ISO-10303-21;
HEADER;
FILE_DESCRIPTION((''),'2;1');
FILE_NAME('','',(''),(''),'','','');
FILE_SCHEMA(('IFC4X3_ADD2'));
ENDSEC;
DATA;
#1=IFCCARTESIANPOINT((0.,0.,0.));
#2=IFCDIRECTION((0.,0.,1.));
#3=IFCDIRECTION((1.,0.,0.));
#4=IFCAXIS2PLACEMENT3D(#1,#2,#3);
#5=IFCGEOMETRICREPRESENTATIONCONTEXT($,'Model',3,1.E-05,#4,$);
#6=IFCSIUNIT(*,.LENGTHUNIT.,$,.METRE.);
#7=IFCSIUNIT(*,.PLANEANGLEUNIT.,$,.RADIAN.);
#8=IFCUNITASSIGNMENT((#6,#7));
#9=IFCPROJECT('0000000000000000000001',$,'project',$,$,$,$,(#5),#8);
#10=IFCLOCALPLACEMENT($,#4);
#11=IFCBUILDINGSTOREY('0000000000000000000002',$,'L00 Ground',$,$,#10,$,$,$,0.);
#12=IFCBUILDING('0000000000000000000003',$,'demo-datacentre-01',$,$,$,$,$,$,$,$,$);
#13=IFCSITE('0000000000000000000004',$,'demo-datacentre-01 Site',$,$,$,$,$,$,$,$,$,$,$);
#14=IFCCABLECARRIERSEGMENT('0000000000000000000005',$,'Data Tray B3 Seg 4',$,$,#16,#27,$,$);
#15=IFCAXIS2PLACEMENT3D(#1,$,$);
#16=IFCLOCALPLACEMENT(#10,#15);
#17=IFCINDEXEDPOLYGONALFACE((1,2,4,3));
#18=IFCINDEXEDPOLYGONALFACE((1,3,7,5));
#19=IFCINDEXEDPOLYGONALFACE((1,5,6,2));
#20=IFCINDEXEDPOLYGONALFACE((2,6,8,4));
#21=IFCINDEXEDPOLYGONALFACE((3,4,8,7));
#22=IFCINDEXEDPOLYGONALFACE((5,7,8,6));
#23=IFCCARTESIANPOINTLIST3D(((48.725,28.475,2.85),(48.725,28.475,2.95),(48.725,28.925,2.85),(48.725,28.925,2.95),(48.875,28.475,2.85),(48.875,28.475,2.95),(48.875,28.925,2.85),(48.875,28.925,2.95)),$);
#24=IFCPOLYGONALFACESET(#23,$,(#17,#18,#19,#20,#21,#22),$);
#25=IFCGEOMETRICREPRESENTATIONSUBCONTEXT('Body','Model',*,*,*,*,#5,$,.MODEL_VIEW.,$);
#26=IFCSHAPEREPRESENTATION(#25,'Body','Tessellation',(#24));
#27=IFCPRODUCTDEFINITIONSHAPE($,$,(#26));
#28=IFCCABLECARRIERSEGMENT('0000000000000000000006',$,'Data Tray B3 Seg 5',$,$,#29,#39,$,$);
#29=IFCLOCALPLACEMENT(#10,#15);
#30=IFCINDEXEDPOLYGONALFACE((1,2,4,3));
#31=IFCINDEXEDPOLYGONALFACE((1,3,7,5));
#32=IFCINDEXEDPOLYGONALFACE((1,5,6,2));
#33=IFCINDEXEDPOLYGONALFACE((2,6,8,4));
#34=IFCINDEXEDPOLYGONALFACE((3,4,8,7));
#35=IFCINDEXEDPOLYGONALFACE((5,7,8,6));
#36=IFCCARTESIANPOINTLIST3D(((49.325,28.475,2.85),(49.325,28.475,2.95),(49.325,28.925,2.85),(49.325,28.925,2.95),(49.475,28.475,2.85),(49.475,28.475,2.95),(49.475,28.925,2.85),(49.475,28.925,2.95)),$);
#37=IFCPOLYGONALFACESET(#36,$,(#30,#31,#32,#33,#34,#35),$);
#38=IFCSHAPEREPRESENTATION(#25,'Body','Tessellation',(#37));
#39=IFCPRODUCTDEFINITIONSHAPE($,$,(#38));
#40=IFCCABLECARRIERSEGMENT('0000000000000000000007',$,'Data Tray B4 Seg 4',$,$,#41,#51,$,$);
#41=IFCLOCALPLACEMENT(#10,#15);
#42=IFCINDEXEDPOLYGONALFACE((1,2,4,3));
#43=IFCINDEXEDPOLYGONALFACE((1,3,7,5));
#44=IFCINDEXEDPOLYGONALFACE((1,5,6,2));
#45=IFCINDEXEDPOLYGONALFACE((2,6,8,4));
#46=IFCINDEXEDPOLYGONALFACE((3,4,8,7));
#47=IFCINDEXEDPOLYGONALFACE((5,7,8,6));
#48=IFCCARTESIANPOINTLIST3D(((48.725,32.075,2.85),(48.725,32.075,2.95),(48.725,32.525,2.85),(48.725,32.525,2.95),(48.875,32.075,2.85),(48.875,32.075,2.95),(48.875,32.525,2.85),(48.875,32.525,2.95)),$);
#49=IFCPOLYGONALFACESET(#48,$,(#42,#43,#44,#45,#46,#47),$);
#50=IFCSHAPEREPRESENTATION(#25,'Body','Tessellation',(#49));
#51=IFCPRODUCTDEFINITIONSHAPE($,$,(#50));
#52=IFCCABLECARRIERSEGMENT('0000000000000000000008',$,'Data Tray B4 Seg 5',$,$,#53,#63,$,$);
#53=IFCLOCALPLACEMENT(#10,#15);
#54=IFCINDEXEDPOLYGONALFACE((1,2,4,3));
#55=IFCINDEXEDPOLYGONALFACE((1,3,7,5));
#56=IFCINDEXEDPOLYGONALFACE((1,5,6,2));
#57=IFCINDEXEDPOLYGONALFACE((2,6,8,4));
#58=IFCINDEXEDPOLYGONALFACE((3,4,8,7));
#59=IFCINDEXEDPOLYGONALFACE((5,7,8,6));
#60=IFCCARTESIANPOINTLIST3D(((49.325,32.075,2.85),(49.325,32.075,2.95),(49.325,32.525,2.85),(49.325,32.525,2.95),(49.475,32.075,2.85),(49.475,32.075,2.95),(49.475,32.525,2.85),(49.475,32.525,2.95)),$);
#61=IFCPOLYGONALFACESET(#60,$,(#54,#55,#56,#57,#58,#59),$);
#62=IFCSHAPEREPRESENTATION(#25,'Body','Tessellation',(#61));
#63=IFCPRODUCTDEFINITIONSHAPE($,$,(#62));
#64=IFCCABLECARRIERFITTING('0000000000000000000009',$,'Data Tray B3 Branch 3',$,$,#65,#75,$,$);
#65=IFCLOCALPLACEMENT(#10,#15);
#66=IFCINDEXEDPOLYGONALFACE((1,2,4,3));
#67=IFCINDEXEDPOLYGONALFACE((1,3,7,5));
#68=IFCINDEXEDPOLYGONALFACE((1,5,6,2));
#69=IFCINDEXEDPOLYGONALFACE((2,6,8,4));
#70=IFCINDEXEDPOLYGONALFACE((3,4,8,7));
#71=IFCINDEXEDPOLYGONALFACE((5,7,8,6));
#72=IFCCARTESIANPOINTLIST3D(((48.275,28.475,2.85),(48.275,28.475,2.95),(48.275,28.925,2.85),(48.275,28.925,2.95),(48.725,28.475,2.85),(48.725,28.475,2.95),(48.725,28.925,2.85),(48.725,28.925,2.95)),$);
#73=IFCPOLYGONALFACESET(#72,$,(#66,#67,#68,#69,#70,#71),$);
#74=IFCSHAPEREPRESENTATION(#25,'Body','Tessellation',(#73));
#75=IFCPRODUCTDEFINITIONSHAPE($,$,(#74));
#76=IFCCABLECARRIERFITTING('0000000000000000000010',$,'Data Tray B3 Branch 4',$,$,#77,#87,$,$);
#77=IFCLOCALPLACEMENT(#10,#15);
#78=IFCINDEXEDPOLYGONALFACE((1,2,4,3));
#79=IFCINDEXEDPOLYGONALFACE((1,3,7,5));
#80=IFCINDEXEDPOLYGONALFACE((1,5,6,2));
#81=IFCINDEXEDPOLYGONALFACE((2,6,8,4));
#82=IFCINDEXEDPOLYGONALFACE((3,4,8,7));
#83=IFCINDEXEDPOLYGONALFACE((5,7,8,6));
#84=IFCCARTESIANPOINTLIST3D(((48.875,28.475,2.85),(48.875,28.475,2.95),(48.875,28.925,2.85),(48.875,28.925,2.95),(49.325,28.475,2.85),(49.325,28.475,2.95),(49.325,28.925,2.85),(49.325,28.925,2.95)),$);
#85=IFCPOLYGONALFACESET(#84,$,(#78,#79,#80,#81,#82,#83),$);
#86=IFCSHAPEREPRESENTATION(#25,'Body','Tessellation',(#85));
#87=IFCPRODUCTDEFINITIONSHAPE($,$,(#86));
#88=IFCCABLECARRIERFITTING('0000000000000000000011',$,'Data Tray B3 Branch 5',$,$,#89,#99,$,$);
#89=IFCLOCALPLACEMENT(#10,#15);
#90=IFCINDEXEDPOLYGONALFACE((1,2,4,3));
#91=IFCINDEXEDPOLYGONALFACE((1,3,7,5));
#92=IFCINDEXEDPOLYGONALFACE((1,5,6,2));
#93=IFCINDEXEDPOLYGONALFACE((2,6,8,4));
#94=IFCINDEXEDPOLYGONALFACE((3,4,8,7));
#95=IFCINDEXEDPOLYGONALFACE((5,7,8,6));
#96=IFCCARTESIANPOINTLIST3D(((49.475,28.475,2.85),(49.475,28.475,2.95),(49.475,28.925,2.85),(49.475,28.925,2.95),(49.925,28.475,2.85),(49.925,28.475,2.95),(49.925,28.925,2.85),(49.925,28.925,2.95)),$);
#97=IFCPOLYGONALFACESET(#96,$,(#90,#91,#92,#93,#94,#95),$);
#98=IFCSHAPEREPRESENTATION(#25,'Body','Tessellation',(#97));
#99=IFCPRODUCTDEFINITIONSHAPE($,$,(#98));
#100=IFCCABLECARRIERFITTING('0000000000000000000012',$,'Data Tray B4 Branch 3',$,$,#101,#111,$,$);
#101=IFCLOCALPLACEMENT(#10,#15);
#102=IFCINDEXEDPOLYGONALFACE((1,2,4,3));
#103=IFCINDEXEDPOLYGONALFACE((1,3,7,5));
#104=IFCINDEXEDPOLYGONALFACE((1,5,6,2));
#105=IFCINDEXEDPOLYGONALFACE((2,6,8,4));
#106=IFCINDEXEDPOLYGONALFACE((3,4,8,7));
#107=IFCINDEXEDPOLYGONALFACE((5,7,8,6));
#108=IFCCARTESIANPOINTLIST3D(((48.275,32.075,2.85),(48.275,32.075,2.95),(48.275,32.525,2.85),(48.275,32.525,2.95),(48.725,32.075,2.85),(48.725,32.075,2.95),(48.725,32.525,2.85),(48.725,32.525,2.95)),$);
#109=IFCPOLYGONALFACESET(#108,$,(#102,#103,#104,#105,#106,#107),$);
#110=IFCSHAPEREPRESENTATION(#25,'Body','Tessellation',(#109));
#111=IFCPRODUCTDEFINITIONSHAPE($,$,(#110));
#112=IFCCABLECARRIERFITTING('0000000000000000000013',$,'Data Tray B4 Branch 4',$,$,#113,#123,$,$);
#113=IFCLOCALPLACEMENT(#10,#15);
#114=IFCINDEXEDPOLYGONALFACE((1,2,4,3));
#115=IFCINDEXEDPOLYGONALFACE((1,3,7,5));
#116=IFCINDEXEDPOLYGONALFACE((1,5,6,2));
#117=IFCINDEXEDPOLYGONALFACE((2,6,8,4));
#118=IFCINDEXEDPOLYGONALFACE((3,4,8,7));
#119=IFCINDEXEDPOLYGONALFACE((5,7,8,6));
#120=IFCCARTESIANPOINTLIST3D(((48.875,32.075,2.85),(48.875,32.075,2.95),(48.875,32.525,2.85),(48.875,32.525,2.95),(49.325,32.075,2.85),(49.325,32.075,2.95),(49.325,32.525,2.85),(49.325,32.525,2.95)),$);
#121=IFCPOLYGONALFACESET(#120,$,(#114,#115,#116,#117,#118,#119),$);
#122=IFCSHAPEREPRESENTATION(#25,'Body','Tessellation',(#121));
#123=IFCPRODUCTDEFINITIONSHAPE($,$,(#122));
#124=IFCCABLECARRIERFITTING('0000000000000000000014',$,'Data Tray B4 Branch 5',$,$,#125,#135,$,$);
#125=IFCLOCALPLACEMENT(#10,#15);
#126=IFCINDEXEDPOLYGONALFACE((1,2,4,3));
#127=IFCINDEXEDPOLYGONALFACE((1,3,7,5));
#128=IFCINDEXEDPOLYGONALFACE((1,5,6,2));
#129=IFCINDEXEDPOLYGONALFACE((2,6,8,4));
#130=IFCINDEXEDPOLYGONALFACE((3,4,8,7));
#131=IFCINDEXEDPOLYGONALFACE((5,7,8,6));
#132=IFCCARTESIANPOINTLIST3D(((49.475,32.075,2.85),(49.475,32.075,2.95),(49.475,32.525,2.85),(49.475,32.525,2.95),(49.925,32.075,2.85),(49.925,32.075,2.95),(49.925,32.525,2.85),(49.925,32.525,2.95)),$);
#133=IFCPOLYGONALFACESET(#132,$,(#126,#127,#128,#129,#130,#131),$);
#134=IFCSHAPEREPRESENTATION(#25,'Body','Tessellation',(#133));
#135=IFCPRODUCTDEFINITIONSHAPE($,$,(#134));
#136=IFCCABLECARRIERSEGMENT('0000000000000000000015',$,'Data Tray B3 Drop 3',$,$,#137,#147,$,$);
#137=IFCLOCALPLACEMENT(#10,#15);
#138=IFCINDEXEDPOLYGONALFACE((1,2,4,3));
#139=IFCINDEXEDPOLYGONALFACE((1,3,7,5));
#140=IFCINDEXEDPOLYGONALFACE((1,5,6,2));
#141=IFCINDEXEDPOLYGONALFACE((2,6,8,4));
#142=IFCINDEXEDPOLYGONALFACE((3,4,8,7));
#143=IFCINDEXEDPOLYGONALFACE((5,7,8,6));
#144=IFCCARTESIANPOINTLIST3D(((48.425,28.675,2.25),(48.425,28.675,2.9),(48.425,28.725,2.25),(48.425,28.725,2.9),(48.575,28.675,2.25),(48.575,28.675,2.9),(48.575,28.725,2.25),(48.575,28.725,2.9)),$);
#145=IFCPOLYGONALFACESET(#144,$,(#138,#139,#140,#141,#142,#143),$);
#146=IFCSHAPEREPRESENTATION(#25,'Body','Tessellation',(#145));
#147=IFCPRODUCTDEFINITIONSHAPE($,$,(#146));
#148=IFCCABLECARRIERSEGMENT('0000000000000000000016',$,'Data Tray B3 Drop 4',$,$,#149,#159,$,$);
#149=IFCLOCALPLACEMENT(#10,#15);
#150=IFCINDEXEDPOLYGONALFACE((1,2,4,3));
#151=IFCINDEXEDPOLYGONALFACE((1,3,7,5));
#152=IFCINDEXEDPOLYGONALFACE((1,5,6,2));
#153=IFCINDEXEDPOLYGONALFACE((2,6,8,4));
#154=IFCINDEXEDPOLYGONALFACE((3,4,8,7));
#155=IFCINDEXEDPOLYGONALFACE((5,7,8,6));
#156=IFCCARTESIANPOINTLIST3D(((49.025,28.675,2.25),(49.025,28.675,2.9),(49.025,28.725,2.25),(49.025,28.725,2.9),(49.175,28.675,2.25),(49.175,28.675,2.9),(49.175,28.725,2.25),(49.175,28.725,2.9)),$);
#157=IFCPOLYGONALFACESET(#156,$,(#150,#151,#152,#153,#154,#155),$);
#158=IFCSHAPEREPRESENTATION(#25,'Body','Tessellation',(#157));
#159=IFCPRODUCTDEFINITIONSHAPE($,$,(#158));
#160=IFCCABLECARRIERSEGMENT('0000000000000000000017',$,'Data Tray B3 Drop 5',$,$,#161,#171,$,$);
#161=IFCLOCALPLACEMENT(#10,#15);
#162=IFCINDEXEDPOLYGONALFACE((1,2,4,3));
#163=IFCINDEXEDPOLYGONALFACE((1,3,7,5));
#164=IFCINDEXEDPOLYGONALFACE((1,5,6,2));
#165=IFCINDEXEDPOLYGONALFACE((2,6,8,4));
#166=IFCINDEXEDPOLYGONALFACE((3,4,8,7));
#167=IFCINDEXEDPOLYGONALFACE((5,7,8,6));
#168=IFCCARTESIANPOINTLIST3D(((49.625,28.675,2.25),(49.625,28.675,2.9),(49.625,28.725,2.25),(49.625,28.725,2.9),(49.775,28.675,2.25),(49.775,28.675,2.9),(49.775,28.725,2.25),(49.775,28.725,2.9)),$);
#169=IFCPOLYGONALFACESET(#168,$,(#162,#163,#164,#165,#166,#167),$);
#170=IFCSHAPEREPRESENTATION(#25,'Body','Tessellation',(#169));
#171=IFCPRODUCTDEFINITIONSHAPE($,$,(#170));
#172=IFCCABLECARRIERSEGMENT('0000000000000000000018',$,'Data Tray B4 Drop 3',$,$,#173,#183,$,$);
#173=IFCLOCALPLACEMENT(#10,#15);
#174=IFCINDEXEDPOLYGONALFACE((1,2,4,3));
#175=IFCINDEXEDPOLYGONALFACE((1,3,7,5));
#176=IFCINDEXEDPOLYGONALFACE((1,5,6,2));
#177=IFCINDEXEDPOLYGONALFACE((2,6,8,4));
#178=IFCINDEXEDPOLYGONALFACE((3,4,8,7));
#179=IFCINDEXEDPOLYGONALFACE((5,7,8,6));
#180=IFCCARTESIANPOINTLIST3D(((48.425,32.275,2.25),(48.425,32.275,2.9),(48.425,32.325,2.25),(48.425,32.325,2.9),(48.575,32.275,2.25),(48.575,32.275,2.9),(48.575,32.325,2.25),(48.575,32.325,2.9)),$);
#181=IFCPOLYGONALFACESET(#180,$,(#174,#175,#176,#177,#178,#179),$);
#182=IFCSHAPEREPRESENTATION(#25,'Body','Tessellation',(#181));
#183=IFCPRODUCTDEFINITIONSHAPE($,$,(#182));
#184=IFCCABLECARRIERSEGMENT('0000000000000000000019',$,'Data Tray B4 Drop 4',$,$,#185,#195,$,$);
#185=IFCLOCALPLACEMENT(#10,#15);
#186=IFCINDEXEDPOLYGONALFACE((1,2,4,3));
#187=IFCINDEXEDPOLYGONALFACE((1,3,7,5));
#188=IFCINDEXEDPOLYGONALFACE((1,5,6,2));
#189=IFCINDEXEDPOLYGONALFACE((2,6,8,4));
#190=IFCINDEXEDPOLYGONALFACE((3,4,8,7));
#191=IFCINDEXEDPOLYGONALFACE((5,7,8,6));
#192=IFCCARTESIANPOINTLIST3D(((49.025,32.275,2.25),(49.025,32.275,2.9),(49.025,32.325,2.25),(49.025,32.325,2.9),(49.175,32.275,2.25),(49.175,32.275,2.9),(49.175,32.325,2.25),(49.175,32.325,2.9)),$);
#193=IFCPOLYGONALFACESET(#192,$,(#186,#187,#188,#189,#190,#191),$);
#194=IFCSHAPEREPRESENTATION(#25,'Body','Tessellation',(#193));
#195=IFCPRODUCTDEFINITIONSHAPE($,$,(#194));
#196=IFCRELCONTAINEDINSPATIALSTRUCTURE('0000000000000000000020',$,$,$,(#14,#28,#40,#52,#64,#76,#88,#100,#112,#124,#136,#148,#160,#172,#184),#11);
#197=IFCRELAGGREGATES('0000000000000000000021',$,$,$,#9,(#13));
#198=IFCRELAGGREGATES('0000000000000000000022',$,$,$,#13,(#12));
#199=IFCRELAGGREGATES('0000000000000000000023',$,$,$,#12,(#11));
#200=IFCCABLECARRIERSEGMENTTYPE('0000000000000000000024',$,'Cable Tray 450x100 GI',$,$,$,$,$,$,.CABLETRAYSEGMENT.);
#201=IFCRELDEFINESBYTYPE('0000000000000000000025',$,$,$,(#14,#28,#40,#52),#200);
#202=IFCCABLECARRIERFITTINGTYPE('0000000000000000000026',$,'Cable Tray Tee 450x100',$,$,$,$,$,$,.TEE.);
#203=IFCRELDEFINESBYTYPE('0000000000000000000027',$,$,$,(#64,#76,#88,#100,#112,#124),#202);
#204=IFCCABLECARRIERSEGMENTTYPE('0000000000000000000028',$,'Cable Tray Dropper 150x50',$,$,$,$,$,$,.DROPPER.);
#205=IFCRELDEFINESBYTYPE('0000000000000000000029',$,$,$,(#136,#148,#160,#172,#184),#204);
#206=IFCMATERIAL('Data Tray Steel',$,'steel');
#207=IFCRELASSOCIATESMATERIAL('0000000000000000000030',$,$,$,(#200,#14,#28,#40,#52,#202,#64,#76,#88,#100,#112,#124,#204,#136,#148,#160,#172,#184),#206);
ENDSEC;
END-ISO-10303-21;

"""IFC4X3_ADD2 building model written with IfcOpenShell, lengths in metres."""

from ifc_helpers import new_model, si_unit, frame, origin_with_axes, place, context, subcontext, project, spatial, rectangle, extrude, material, type_object, element, save


model = new_model("IFC4X3_ADD2")

# Units and contexts
model_context = context("Model", 3, precision=1e-05, world=origin_with_axes())
body_context = subcontext(model_context, "Body", "Model", "MODEL_VIEW")
ifc_project = project(units=[si_unit("LENGTHUNIT", "METRE"), si_unit("PLANEANGLEUNIT", "RADIAN")], contexts=[model_context])

# Site, building, storey
site = spatial("IfcSite", under=ifc_project, Name="demo-datacentre-01 Site")
building = spatial("IfcBuilding", under=site, Name="demo-datacentre-01")
storey_placement = place(None, origin_with_axes())
storey = spatial("IfcBuildingStorey", under=building, at=storey_placement, Name="L00 Ground", Elevation=0.0)

# Cable carrier segments
ifc_material_1 = material(Name="Data Tray Steel", Category="steel")
cable_carrier_segment_type_1 = type_object("IfcCableCarrierSegmentType", Name="Cable Tray 450x100 GI", PredefinedType="CABLETRAYSEGMENT", material=ifc_material_1)
cable_carrier_segment_1_placement = place(storey_placement, frame((48.725, 28.7, 2.9), z_axis=(1.0, 0.0, 0.0), x_axis=(0.0, 1.0, 0.0)))
element("IfcCableCarrierSegment", 1, at=cable_carrier_segment_1_placement, inside=storey, type_object=cable_carrier_segment_type_1, material=ifc_material_1, Name="Data Tray B3 Seg 4", context=body_context, shape_type="SweptSolid", body=[
    extrude(rectangle(XDim=0.45, YDim=0.1), origin_with_axes(), (0.0, 0.0, 1.0), 0.15),
])
cable_carrier_segment_2_placement = place(storey_placement, frame((49.325, 28.7, 2.9), z_axis=(1.0, 0.0, 0.0), x_axis=(0.0, 1.0, 0.0)))
element("IfcCableCarrierSegment", 2, at=cable_carrier_segment_2_placement, inside=storey, type_object=cable_carrier_segment_type_1, material=ifc_material_1, Name="Data Tray B3 Seg 5", context=body_context, shape_type="SweptSolid", body=[
    extrude(rectangle(XDim=0.45, YDim=0.1), origin_with_axes(), (0.0, 0.0, 1.0), 0.15),
])
cable_carrier_segment_3_placement = place(storey_placement, frame((48.725, 32.3, 2.9), z_axis=(1.0, 0.0, 0.0), x_axis=(0.0, 1.0, 0.0)))
element("IfcCableCarrierSegment", 3, at=cable_carrier_segment_3_placement, inside=storey, type_object=cable_carrier_segment_type_1, material=ifc_material_1, Name="Data Tray B4 Seg 4", context=body_context, shape_type="SweptSolid", body=[
    extrude(rectangle(XDim=0.45, YDim=0.1), origin_with_axes(), (0.0, 0.0, 1.0), 0.15),
])
cable_carrier_segment_4_placement = place(storey_placement, frame((49.325, 32.3, 2.9), z_axis=(1.0, 0.0, 0.0), x_axis=(0.0, 1.0, 0.0)))
element("IfcCableCarrierSegment", 4, at=cable_carrier_segment_4_placement, inside=storey, type_object=cable_carrier_segment_type_1, material=ifc_material_1, Name="Data Tray B4 Seg 5", context=body_context, shape_type="SweptSolid", body=[
    extrude(rectangle(XDim=0.45, YDim=0.1), origin_with_axes(), (0.0, 0.0, 1.0), 0.15),
])

# Cable carrier fittings
cable_carrier_fitting_type = type_object("IfcCableCarrierFittingType", Name="Cable Tray Tee 450x100", PredefinedType="TEE", material=ifc_material_1)
for number, where, z_axis, x_axis, name in (
    (5, (48.5, 28.7, 2.85), (0.0, 0.0, 1.0), (1.0, 0.0, 0.0), "Data Tray B3 Branch 3"),
    (6, (49.1, 28.7, 2.85), (0.0, 0.0, 1.0), (1.0, 0.0, 0.0), "Data Tray B3 Branch 4"),
    (7, (49.7, 28.7, 2.85), (0.0, 0.0, 1.0), (1.0, 0.0, 0.0), "Data Tray B3 Branch 5"),
    (8, (48.5, 32.3, 2.85), (0.0, 0.0, 1.0), (1.0, 0.0, 0.0), "Data Tray B4 Branch 3"),
    (9, (49.1, 32.3, 2.85), (0.0, 0.0, 1.0), (1.0, 0.0, 0.0), "Data Tray B4 Branch 4"),
    (10, (49.7, 32.3, 2.85), (0.0, 0.0, 1.0), (1.0, 0.0, 0.0), "Data Tray B4 Branch 5"),
):
    element("IfcCableCarrierFitting", number, at=place(storey_placement, frame(where, z_axis=z_axis, x_axis=x_axis)), inside=storey, type_object=cable_carrier_fitting_type, material=ifc_material_1, Name=name, context=body_context, shape_type="SweptSolid", body=[
        extrude(rectangle(XDim=0.45, YDim=0.45), origin_with_axes(), (0.0, 0.0, 1.0), 0.1),
    ])

# Cable carrier segments
cable_carrier_segment_type_2 = type_object("IfcCableCarrierSegmentType", Name="Cable Tray Dropper 150x50", PredefinedType="DROPPER", material=ifc_material_1)
for number, where, z_axis, x_axis, name in (
    (11, (48.5, 28.7, 2.9), (0.0, 0.0, -1.0), (1.0, 0.0, 0.0), "Data Tray B3 Drop 3"),
    (12, (49.1, 28.7, 2.9), (0.0, 0.0, -1.0), (1.0, 0.0, 0.0), "Data Tray B3 Drop 4"),
    (13, (49.7, 28.7, 2.9), (0.0, 0.0, -1.0), (1.0, 0.0, 0.0), "Data Tray B3 Drop 5"),
    (14, (48.5, 32.3, 2.9), (0.0, 0.0, -1.0), (1.0, 0.0, 0.0), "Data Tray B4 Drop 3"),
    (15, (49.1, 32.3, 2.9), (0.0, 0.0, -1.0), (1.0, 0.0, 0.0), "Data Tray B4 Drop 4"),
):
    element("IfcCableCarrierSegment", number, at=place(storey_placement, frame(where, z_axis=z_axis, x_axis=x_axis)), inside=storey, type_object=cable_carrier_segment_type_2, material=ifc_material_1, Name=name, context=body_context, shape_type="SweptSolid", body=[
        extrude(rectangle(XDim=0.15, YDim=0.05), origin_with_axes(), (0.0, 0.0, 1.0), 0.65),
    ])

save(model, "model.ifc")
